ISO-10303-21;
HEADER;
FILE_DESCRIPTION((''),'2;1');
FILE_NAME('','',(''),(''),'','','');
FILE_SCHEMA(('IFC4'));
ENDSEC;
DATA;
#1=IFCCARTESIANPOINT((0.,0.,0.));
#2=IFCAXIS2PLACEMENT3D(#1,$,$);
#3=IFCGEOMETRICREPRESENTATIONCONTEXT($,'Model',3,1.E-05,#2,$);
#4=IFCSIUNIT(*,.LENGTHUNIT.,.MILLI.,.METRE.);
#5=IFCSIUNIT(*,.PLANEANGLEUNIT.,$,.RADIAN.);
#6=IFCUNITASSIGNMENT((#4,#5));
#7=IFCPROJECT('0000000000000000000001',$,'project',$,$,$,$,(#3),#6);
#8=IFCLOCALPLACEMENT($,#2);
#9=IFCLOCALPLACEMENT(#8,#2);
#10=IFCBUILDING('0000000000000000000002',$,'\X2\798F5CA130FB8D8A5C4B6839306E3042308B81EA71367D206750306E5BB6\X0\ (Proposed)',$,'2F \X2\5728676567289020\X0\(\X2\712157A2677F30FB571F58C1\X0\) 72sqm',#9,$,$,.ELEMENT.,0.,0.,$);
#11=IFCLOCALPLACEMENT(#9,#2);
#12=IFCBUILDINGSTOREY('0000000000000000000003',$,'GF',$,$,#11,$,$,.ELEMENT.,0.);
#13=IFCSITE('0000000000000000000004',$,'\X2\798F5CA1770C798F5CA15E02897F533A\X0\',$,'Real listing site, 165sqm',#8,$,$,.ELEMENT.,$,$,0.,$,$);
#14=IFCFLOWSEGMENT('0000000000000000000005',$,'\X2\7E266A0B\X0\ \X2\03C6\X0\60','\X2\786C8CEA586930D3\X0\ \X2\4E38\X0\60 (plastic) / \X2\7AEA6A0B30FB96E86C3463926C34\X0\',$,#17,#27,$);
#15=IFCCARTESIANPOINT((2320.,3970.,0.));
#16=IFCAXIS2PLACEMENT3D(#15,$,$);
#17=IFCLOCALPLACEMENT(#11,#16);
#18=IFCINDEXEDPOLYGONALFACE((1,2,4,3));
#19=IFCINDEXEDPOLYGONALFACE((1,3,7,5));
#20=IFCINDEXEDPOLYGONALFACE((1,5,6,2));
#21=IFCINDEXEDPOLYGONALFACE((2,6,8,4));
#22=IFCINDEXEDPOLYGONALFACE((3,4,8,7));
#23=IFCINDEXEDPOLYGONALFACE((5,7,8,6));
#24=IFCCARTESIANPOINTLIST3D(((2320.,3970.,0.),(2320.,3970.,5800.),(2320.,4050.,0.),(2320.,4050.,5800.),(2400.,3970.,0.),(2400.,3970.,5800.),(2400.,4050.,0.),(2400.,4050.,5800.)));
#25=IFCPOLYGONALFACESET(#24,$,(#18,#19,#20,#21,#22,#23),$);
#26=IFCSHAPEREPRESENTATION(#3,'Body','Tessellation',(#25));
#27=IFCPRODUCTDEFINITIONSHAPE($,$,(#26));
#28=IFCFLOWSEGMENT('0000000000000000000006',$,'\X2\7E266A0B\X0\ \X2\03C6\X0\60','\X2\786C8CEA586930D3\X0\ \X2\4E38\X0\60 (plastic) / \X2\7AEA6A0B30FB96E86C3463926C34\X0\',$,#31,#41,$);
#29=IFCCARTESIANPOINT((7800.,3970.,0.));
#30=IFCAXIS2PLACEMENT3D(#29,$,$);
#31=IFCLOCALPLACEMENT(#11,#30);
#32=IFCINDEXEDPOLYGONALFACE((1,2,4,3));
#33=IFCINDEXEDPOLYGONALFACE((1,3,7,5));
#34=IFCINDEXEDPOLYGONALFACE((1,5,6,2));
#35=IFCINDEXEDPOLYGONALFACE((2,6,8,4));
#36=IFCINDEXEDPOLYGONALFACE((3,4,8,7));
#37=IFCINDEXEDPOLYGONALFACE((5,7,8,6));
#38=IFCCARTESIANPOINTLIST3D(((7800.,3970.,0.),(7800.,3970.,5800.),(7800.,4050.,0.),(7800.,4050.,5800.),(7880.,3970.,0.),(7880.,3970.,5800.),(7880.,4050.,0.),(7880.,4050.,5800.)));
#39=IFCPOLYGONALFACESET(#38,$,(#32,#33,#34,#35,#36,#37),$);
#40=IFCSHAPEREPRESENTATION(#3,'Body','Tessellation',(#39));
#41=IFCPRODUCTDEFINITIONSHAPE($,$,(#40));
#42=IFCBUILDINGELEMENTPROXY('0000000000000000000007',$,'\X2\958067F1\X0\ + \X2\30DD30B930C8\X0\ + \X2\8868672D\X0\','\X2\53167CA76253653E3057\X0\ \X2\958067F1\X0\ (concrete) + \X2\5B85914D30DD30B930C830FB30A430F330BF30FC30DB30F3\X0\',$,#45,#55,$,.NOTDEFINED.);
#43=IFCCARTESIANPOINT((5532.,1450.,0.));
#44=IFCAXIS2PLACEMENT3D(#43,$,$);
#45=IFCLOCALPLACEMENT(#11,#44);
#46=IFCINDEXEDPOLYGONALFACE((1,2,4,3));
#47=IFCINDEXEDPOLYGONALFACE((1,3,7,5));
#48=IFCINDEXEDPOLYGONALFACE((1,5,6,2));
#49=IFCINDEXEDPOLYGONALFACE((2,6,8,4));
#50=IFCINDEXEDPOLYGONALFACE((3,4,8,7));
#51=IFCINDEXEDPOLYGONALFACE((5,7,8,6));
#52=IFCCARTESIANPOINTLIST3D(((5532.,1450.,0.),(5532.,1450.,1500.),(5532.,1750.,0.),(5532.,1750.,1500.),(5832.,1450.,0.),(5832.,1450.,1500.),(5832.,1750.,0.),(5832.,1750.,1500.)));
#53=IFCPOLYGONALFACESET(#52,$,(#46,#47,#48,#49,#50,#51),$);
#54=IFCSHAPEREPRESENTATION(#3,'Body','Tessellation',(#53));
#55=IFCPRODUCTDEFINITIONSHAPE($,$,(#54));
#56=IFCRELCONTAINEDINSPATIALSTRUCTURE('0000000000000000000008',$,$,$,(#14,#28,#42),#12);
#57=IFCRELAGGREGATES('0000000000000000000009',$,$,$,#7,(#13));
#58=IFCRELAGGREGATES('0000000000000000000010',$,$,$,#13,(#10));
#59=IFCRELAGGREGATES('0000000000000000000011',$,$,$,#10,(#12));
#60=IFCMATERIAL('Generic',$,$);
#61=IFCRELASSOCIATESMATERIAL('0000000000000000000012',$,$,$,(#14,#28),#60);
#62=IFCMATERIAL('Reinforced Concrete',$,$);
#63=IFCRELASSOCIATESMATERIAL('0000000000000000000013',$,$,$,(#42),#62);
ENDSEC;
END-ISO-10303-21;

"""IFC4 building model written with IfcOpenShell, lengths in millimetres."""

from ifc_helpers import new_model, si_unit, frame, frame_2d, origin, place, context, project, spatial, rectangle, extrude, material, element, save


model = new_model("IFC4")

# Units and contexts
model_context = context("Model", 3, precision=1e-05, world=origin())
ifc_project = project(units=[si_unit("LENGTHUNIT", "METRE", prefix="MILLI"), si_unit("PLANEANGLEUNIT", "RADIAN")], contexts=[model_context])

# Site, building, storey
site_placement = place(None, origin())
site = spatial("IfcSite", under=ifc_project, at=site_placement, Name="福岡県福岡市西区", ObjectType="Real listing site, 165sqm", CompositionType="ELEMENT", RefElevation=0.0)
building_placement = place(site_placement, origin())
building = spatial("IfcBuilding", under=site, at=building_placement, Name="福岡・越屋根のある自然素材の家 (Proposed)", ObjectType="2F 在来木造(無垢板・土壁) 72sqm", CompositionType="ELEMENT", ElevationOfRefHeight=0.0, ElevationOfTerrain=0.0)
storey_placement = place(building_placement, origin())
storey = spatial("IfcBuildingStorey", under=building, at=storey_placement, Name="GF", CompositionType="ELEMENT", Elevation=0.0)

# Shared definitions
ifc_material_1 = material(Name="Reinforced Concrete")

# Flow segments
ifc_material_2 = material(Name="Generic")
flow_segment_1_placement = place(storey_placement, frame((2320.0, 3970.0, 0.0)))
element("IfcFlowSegment", 1, at=flow_segment_1_placement, inside=storey, material=ifc_material_2, Name="縦樋 φ60", Description="硬質塩ビ 丸60 (plastic) / 竪樋・雨水排水", context=model_context, shape_type="SweptSolid", body=[
    extrude(rectangle(XDim=80.0, YDim=80.0, at=frame_2d((40.0, 40.0))), frame((2320.0, 3970.0, 0.0)), (0.0, 0.0, 1.0), 5800.0),
])
flow_segment_2_placement = place(storey_placement, frame((7800.0, 3970.0, 0.0)))
element("IfcFlowSegment", 2, at=flow_segment_2_placement, inside=storey, material=ifc_material_2, Name="縦樋 φ60", Description="硬質塩ビ 丸60 (plastic) / 竪樋・雨水排水", context=model_context, shape_type="SweptSolid", body=[
    extrude(rectangle(XDim=80.0, YDim=80.0, at=frame_2d((40.0, 40.0))), frame((7800.0, 3970.0, 0.0)), (0.0, 0.0, 1.0), 5800.0),
])

# Building element proxy
proxy_placement = place(storey_placement, frame((5532.0, 1450.0, 0.0)))
element("IfcBuildingElementProxy", 3, at=proxy_placement, inside=storey, material=ifc_material_1, Name="門柱 + ポスト + 表札", Description="化粧打放し 門柱 (concrete) + 宅配ポスト・インターホン", PredefinedType="NOTDEFINED", context=model_context, shape_type="SweptSolid", body=[
    extrude(rectangle(XDim=300.0, YDim=300.0, at=frame_2d((150.0, 150.0))), frame((5532.0, 1450.0, 0.0)), (0.0, 0.0, 1.0), 1500.0),
])

save(model, "model.ifc")
